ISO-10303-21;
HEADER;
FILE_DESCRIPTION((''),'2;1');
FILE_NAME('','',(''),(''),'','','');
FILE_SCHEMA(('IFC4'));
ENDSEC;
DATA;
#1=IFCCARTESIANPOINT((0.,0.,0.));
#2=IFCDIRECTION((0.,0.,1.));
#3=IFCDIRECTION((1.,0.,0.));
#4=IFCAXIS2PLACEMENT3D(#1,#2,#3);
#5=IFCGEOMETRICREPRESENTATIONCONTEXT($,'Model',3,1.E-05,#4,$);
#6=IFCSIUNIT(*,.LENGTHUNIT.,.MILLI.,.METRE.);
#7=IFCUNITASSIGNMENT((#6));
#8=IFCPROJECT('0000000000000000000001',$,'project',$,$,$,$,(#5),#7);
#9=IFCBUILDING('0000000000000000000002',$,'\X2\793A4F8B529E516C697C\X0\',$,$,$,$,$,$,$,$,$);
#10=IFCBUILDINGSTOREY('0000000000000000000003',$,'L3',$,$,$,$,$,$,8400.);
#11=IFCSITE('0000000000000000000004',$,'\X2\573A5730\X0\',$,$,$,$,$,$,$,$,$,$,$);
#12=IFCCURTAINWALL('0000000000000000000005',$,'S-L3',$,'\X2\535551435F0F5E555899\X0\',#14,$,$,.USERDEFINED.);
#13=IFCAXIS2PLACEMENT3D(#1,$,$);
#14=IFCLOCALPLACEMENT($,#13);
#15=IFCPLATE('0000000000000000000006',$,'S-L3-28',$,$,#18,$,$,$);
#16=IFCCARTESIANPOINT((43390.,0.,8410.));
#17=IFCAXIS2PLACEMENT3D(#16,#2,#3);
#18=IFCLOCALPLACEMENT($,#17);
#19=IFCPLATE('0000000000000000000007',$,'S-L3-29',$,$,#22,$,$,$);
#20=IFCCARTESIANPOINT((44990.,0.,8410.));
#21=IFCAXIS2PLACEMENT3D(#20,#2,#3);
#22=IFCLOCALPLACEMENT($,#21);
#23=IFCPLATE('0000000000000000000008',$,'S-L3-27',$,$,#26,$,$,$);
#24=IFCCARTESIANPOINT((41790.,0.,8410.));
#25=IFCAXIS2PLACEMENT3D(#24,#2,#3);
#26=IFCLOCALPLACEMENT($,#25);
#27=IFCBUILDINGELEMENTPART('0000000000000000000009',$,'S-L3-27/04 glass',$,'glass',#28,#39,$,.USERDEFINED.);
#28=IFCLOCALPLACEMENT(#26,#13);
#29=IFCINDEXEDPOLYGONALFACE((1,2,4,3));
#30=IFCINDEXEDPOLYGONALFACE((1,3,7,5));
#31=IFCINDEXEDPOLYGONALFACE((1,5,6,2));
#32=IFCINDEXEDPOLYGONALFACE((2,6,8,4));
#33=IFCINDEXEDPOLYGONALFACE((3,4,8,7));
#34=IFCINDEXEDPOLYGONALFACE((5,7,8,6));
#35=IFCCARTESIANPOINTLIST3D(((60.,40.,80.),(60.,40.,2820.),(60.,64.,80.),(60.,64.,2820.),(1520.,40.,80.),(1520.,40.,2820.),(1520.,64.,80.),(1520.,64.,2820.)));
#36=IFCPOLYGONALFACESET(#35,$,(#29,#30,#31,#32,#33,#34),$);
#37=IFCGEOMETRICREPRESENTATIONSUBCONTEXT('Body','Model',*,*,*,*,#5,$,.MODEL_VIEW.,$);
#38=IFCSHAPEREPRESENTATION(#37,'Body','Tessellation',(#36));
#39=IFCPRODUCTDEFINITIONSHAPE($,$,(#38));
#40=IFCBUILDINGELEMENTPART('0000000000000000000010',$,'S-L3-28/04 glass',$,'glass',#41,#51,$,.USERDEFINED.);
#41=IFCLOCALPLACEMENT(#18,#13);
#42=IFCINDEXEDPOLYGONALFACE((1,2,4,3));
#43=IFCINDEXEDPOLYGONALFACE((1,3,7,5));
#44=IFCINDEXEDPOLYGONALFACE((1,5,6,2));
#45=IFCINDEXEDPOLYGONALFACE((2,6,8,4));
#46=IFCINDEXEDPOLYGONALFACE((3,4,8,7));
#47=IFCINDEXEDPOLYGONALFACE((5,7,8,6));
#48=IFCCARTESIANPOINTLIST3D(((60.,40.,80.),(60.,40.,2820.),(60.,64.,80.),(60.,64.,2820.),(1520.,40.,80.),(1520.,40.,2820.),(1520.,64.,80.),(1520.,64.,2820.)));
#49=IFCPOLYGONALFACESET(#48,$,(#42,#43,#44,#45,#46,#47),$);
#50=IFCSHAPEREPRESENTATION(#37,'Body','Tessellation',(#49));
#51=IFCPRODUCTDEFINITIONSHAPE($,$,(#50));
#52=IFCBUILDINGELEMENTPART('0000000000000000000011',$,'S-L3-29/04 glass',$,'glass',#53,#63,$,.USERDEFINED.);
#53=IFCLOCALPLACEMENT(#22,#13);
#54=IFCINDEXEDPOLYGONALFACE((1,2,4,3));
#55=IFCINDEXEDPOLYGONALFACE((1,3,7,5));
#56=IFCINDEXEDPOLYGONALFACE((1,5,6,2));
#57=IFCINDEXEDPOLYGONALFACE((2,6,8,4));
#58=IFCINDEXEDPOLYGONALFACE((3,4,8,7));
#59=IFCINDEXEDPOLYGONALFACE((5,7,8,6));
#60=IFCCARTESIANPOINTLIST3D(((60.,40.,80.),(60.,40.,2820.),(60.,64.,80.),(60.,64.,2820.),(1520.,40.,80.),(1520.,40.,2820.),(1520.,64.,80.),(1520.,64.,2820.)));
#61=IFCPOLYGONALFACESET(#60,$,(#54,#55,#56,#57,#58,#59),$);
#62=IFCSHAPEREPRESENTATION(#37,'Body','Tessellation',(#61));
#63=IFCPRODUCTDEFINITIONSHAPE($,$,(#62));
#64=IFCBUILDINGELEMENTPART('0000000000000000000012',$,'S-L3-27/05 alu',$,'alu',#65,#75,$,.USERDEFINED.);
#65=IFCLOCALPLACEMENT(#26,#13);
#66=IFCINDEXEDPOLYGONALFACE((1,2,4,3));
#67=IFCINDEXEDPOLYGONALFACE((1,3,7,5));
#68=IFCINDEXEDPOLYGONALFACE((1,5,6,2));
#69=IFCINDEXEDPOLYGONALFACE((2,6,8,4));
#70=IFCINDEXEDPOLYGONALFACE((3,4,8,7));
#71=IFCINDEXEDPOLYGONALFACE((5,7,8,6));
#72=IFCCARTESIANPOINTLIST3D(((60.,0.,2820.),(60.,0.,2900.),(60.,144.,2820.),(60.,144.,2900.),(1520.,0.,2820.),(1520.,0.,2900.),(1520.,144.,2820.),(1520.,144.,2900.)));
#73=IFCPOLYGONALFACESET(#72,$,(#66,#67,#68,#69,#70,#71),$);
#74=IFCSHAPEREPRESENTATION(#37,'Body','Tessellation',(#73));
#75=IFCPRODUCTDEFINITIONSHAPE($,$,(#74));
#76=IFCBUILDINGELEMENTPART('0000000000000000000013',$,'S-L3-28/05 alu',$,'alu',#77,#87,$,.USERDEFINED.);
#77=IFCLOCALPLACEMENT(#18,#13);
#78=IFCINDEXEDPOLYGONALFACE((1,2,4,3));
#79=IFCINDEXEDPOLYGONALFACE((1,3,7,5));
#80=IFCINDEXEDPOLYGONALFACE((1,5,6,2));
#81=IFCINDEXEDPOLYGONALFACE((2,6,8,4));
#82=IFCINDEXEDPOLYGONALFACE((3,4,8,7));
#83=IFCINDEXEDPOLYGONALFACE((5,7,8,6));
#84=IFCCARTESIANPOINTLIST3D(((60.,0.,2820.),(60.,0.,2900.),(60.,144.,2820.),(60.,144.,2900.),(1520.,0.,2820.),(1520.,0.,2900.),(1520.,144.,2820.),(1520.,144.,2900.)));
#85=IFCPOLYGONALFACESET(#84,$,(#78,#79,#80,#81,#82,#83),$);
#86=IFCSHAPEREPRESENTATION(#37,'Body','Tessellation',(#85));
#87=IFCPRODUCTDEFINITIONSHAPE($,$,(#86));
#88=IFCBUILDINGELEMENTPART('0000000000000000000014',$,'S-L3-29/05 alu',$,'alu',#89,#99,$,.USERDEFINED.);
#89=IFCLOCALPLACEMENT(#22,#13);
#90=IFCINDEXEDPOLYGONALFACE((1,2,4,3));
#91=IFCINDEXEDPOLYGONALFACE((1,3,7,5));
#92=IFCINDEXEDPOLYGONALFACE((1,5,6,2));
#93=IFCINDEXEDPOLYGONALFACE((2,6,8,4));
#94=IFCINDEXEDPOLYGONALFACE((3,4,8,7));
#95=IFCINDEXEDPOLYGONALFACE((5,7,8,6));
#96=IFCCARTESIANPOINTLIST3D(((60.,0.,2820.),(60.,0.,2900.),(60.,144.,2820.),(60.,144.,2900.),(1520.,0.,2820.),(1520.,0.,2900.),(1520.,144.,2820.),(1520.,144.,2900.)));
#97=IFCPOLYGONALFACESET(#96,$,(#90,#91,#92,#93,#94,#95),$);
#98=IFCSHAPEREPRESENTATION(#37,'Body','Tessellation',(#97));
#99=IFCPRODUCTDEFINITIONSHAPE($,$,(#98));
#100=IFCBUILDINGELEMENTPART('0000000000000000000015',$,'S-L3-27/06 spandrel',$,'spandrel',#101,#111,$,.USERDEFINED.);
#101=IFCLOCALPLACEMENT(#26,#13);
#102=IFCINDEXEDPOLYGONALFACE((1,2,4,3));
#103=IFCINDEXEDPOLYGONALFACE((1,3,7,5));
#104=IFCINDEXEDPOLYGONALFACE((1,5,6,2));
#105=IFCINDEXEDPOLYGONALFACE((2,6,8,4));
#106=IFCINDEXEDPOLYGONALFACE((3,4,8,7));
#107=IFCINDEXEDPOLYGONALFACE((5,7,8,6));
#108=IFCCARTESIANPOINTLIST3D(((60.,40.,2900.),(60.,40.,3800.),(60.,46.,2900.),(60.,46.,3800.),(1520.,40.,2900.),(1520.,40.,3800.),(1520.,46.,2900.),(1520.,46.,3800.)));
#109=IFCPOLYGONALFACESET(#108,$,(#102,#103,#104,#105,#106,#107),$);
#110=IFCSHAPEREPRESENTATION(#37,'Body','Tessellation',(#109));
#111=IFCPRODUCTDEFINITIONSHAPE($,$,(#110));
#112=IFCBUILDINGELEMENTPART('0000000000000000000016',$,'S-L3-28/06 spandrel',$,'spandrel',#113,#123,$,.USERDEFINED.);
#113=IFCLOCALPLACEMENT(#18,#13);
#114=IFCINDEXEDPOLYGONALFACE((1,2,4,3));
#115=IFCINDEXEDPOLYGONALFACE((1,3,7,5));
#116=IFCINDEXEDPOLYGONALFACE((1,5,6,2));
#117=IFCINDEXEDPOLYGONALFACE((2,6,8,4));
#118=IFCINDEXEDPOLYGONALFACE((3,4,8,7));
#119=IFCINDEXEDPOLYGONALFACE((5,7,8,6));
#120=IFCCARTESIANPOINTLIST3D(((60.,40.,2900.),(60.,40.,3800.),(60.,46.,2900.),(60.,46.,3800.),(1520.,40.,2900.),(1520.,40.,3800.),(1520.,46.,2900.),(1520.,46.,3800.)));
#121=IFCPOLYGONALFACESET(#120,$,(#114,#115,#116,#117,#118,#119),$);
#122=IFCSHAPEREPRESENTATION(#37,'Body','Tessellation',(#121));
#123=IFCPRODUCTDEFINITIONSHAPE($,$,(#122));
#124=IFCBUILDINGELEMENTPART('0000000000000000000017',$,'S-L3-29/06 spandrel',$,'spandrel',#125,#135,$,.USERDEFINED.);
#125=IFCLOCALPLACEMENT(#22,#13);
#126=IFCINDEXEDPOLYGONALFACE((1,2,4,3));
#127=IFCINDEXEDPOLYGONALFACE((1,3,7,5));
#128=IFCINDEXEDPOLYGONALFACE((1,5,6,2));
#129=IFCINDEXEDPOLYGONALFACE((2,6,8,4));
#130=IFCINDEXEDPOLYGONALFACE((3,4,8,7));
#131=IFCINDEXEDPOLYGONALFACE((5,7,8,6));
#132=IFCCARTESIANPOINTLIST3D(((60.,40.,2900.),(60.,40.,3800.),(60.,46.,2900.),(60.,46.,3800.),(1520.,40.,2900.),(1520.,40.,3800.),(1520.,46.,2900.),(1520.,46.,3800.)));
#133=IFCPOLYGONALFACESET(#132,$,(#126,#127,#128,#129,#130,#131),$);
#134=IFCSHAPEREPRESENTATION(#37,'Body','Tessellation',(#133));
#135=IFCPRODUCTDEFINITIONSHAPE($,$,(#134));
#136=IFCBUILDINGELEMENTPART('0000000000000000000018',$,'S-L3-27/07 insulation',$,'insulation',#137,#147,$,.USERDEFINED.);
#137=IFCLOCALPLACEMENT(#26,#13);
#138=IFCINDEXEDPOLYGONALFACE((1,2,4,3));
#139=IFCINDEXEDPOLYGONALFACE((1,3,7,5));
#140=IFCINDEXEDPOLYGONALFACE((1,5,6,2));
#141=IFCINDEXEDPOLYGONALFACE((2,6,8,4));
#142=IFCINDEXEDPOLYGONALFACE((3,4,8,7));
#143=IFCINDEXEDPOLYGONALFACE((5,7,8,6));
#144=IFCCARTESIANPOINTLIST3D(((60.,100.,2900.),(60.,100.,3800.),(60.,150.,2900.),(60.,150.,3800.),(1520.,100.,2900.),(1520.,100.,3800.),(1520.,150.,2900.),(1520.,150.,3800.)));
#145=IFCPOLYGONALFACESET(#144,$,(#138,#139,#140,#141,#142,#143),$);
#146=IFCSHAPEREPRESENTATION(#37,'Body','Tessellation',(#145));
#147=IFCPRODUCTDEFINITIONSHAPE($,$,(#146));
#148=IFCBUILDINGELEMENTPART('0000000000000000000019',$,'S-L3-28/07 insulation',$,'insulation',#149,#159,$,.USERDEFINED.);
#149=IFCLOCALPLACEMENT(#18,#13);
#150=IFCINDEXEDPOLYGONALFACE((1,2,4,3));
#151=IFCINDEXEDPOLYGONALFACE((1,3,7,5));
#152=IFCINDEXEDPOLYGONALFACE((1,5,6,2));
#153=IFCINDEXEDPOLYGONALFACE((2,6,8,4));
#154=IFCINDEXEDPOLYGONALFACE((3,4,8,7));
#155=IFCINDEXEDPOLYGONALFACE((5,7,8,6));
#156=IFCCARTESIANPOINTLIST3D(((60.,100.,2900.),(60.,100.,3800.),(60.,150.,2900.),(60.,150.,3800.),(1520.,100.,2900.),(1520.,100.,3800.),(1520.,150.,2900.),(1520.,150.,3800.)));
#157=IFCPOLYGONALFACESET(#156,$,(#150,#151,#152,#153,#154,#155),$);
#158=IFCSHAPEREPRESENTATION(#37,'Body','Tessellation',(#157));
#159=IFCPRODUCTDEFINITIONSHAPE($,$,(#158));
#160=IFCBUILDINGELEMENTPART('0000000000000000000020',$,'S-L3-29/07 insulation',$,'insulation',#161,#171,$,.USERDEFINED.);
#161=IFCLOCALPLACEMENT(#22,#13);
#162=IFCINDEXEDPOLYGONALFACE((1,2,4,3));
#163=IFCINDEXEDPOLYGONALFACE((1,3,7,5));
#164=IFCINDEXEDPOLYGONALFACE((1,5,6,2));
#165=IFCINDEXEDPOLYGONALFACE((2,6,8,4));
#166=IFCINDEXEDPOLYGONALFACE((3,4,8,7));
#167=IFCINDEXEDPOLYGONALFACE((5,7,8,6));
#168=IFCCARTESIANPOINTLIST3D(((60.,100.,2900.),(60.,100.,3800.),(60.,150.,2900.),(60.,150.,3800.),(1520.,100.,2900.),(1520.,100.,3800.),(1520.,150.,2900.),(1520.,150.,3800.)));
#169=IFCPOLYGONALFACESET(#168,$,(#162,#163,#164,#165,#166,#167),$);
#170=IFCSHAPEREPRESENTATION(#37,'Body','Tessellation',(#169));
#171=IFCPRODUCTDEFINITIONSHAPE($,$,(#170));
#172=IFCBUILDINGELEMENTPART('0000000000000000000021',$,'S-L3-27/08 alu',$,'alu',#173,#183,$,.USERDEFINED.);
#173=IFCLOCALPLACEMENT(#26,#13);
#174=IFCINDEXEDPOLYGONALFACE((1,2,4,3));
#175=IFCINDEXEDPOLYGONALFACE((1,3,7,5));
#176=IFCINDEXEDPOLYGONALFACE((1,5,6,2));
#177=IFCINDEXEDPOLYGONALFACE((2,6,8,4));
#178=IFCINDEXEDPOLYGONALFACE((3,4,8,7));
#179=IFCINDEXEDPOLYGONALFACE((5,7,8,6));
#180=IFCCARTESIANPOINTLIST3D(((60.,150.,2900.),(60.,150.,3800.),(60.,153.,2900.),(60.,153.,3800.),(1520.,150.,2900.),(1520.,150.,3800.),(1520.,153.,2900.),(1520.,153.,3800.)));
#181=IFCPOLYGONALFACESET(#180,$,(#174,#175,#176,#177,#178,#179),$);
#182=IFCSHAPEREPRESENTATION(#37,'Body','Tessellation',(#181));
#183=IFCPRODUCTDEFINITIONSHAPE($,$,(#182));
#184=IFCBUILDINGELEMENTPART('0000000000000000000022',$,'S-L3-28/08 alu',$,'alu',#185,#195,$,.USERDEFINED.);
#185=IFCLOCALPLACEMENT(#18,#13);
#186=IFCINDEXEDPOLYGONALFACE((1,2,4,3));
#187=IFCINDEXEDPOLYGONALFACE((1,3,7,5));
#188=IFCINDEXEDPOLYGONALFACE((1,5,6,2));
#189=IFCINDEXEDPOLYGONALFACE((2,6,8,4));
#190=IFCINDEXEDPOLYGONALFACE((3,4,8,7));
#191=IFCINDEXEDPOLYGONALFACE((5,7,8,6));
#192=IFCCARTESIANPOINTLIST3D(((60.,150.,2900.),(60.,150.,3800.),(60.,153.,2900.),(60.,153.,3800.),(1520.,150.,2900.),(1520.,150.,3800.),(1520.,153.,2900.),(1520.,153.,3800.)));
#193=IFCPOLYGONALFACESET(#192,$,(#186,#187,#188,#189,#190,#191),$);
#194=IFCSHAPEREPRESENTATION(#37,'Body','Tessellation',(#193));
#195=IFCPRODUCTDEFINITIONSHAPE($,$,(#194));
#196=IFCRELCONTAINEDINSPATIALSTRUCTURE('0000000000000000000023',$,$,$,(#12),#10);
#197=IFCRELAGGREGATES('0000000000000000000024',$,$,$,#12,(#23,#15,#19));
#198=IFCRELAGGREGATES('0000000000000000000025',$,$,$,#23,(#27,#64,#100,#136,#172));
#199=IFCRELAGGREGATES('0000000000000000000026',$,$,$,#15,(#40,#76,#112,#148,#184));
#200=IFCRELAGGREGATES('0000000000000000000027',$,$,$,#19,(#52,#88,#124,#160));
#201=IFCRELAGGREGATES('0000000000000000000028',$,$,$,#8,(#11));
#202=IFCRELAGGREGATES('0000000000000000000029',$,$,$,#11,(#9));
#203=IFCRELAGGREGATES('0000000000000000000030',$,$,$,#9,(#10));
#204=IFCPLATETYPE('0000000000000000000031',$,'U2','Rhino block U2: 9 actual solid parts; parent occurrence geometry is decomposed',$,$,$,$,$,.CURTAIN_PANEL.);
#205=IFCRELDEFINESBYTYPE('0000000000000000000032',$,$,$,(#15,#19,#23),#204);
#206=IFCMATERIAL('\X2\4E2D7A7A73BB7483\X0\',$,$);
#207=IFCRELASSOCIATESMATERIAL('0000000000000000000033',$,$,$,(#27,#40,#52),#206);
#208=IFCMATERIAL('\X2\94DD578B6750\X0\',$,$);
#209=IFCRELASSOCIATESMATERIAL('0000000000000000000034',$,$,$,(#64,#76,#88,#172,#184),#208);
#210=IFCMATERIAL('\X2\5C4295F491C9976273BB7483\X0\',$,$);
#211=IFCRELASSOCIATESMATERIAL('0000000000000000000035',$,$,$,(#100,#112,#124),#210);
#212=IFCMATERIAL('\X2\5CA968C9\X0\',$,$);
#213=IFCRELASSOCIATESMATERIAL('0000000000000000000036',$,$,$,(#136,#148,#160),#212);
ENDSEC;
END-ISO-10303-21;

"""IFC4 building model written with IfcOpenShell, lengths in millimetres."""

from ifc_helpers import new_model, si_unit, frame, frame_2d, origin, origin_with_axes, place, context, subcontext, project, spatial, rectangle, extrude, source, transform, mapped, material, type_object, element, aggregate, save


model = new_model("IFC4")

# Units and contexts
model_context = context("Model", 3, precision=1e-05, world=origin_with_axes())
body_context = subcontext(model_context, "Body", "Model", "MODEL_VIEW")
ifc_project = project(units=[si_unit("LENGTHUNIT", "METRE", prefix="MILLI")], contexts=[model_context])

# Site, building, storey
site = spatial("IfcSite", under=ifc_project, Name="场地")
building = spatial("IfcBuilding", under=site, Name="示例办公楼")
storey = spatial("IfcBuildingStorey", under=building, Name="L3", Elevation=8400.0)

# Curtain wall, plates, building element parts
curtain_wall = element("IfcCurtainWall", 1, inside=storey, Name="S-L3", ObjectType="单元式幕墙", PredefinedType="USERDEFINED")
plate_type = type_object("IfcPlateType", Name="U2", Description="Rhino block U2: 9 actual solid parts; parent occurrence geometry is decomposed", PredefinedType="CURTAIN_PANEL")
plate_1_placement = place(None, frame((43390.0, 0.0, 8410.0), z_axis=(0.0, 0.0, 1.0), x_axis=(1.0, 0.0, 0.0)))
plate_1 = element("IfcPlate", 2, at=plate_1_placement, type_object=plate_type, Name="S-L3-28")
ifc_material_1 = material(Name="铝型材")
plate_2_placement = place(None, frame((44990.0, 0.0, 8410.0), z_axis=(0.0, 0.0, 1.0), x_axis=(1.0, 0.0, 0.0)))
plate_2 = element("IfcPlate", 3, at=plate_2_placement, type_object=plate_type, Name="S-L3-29")
plate_3_placement = place(None, frame((41790.0, 0.0, 8410.0), z_axis=(0.0, 0.0, 1.0), x_axis=(1.0, 0.0, 0.0)))
plate_3 = element("IfcPlate", 4, at=plate_3_placement, type_object=plate_type, Name="S-L3-27")
aggregate(curtain_wall, [plate_3, plate_1, plate_2])
ifc_material_2 = material(Name="中空玻璃")
shared_shape_1 = source(origin(), body_context, "Body", "SweptSolid", [
    extrude(rectangle(XDim=1460.0, YDim=24.0, at=frame_2d((790.0, 52.0))), frame((0.0, 0.0, 80.0)), (0.0, 0.0, 1.0), 2740.0),
])
building_element_part_1_placement = place(plate_3_placement, origin())
building_element_part_1 = element("IfcBuildingElementPart", 5, at=building_element_part_1_placement, material=ifc_material_2, Name="S-L3-27/04 glass", ObjectType="glass", PredefinedType="USERDEFINED", context=body_context, shape_type="MappedRepresentation", body=[
    mapped(shared_shape_1, transform((0.0, 0.0, 0.0))),
])
building_element_part_2_placement = place(plate_1_placement, origin())
building_element_part_2 = element("IfcBuildingElementPart", 6, at=building_element_part_2_placement, material=ifc_material_2, Name="S-L3-28/04 glass", ObjectType="glass", PredefinedType="USERDEFINED", context=body_context, shape_type="MappedRepresentation", body=[
    mapped(shared_shape_1, transform((0.0, 0.0, 0.0))),
])
building_element_part_3_placement = place(plate_2_placement, origin())
building_element_part_3 = element("IfcBuildingElementPart", 7, at=building_element_part_3_placement, material=ifc_material_2, Name="S-L3-29/04 glass", ObjectType="glass", PredefinedType="USERDEFINED", context=body_context, shape_type="MappedRepresentation", body=[
    mapped(shared_shape_1, transform((0.0, 0.0, 0.0))),
])
shared_shape_2 = source(origin(), body_context, "Body", "SweptSolid", [
    extrude(rectangle(XDim=1460.0, YDim=144.0, at=frame_2d((790.0, 72.0))), frame((0.0, 0.0, 2820.0)), (0.0, 0.0, 1.0), 80.0),
])
building_element_part_4_placement = place(plate_3_placement, origin())
building_element_part_4 = element("IfcBuildingElementPart", 8, at=building_element_part_4_placement, material=ifc_material_1, Name="S-L3-27/05 alu", ObjectType="alu", PredefinedType="USERDEFINED", context=body_context, shape_type="MappedRepresentation", body=[
    mapped(shared_shape_2, transform((0.0, 0.0, 0.0))),
])
building_element_part_5_placement = place(plate_1_placement, origin())
building_element_part_5 = element("IfcBuildingElementPart", 9, at=building_element_part_5_placement, material=ifc_material_1, Name="S-L3-28/05 alu", ObjectType="alu", PredefinedType="USERDEFINED", context=body_context, shape_type="MappedRepresentation", body=[
    mapped(shared_shape_2, transform((0.0, 0.0, 0.0))),
])
building_element_part_6_placement = place(plate_2_placement, origin())
building_element_part_6 = element("IfcBuildingElementPart", 10, at=building_element_part_6_placement, material=ifc_material_1, Name="S-L3-29/05 alu", ObjectType="alu", PredefinedType="USERDEFINED", context=body_context, shape_type="MappedRepresentation", body=[
    mapped(shared_shape_2, transform((0.0, 0.0, 0.0))),
])
ifc_material_3 = material(Name="层间釉面玻璃")
shared_shape_3 = source(origin(), body_context, "Body", "SweptSolid", [
    extrude(rectangle(XDim=1460.0, YDim=6.0, at=frame_2d((790.0, 43.0))), frame((0.0, 0.0, 2900.0)), (0.0, 0.0, 1.0), 900.0),
])
building_element_part_7_placement = place(plate_3_placement, origin())
building_element_part_7 = element("IfcBuildingElementPart", 11, at=building_element_part_7_placement, material=ifc_material_3, Name="S-L3-27/06 spandrel", ObjectType="spandrel", PredefinedType="USERDEFINED", context=body_context, shape_type="MappedRepresentation", body=[
    mapped(shared_shape_3, transform((0.0, 0.0, 0.0))),
])
building_element_part_8_placement = place(plate_1_placement, origin())
building_element_part_8 = element("IfcBuildingElementPart", 12, at=building_element_part_8_placement, material=ifc_material_3, Name="S-L3-28/06 spandrel", ObjectType="spandrel", PredefinedType="USERDEFINED", context=body_context, shape_type="MappedRepresentation", body=[
    mapped(shared_shape_3, transform((0.0, 0.0, 0.0))),
])
building_element_part_9_placement = place(plate_2_placement, origin())
building_element_part_9 = element("IfcBuildingElementPart", 13, at=building_element_part_9_placement, material=ifc_material_3, Name="S-L3-29/06 spandrel", ObjectType="spandrel", PredefinedType="USERDEFINED", context=body_context, shape_type="MappedRepresentation", body=[
    mapped(shared_shape_3, transform((0.0, 0.0, 0.0))),
])
ifc_material_4 = material(Name="岩棉")
shared_shape_4 = source(origin(), body_context, "Body", "SweptSolid", [
    extrude(rectangle(XDim=1460.0, YDim=50.0, at=frame_2d((790.0, 125.0))), frame((0.0, 0.0, 2900.0)), (0.0, 0.0, 1.0), 900.0),
])
building_element_part_10_placement = place(plate_3_placement, origin())
building_element_part_10 = element("IfcBuildingElementPart", 14, at=building_element_part_10_placement, material=ifc_material_4, Name="S-L3-27/07 insulation", ObjectType="insulation", PredefinedType="USERDEFINED", context=body_context, shape_type="MappedRepresentation", body=[
    mapped(shared_shape_4, transform((0.0, 0.0, 0.0))),
])
building_element_part_11_placement = place(plate_1_placement, origin())
building_element_part_11 = element("IfcBuildingElementPart", 15, at=building_element_part_11_placement, material=ifc_material_4, Name="S-L3-28/07 insulation", ObjectType="insulation", PredefinedType="USERDEFINED", context=body_context, shape_type="MappedRepresentation", body=[
    mapped(shared_shape_4, transform((0.0, 0.0, 0.0))),
])
building_element_part_12_placement = place(plate_2_placement, origin())
building_element_part_12 = element("IfcBuildingElementPart", 16, at=building_element_part_12_placement, material=ifc_material_4, Name="S-L3-29/07 insulation", ObjectType="insulation", PredefinedType="USERDEFINED", context=body_context, shape_type="MappedRepresentation", body=[
    mapped(shared_shape_4, transform((0.0, 0.0, 0.0))),
])
shared_shape_5 = source(origin(), body_context, "Body", "SweptSolid", [
    extrude(rectangle(XDim=1460.0, YDim=3.0, at=frame_2d((790.0, 151.5))), frame((0.0, 0.0, 2900.0)), (0.0, 0.0, 1.0), 900.0),
])
building_element_part_13_placement = place(plate_3_placement, origin())
building_element_part_13 = element("IfcBuildingElementPart", 17, at=building_element_part_13_placement, material=ifc_material_1, Name="S-L3-27/08 alu", ObjectType="alu", PredefinedType="USERDEFINED", context=body_context, shape_type="MappedRepresentation", body=[
    mapped(shared_shape_5, transform((0.0, 0.0, 0.0))),
])
building_element_part_14_placement = place(plate_1_placement, origin())
building_element_part_14 = element("IfcBuildingElementPart", 18, at=building_element_part_14_placement, material=ifc_material_1, Name="S-L3-28/08 alu", ObjectType="alu", PredefinedType="USERDEFINED", context=body_context, shape_type="MappedRepresentation", body=[
    mapped(shared_shape_5, transform((0.0, 0.0, 0.0))),
])
aggregate(plate_3, [building_element_part_1, building_element_part_4, building_element_part_7, building_element_part_10, building_element_part_13])
aggregate(plate_1, [building_element_part_2, building_element_part_5, building_element_part_8, building_element_part_11, building_element_part_14])
aggregate(plate_2, [building_element_part_3, building_element_part_6, building_element_part_9, building_element_part_12])

save(model, "model.ifc")
